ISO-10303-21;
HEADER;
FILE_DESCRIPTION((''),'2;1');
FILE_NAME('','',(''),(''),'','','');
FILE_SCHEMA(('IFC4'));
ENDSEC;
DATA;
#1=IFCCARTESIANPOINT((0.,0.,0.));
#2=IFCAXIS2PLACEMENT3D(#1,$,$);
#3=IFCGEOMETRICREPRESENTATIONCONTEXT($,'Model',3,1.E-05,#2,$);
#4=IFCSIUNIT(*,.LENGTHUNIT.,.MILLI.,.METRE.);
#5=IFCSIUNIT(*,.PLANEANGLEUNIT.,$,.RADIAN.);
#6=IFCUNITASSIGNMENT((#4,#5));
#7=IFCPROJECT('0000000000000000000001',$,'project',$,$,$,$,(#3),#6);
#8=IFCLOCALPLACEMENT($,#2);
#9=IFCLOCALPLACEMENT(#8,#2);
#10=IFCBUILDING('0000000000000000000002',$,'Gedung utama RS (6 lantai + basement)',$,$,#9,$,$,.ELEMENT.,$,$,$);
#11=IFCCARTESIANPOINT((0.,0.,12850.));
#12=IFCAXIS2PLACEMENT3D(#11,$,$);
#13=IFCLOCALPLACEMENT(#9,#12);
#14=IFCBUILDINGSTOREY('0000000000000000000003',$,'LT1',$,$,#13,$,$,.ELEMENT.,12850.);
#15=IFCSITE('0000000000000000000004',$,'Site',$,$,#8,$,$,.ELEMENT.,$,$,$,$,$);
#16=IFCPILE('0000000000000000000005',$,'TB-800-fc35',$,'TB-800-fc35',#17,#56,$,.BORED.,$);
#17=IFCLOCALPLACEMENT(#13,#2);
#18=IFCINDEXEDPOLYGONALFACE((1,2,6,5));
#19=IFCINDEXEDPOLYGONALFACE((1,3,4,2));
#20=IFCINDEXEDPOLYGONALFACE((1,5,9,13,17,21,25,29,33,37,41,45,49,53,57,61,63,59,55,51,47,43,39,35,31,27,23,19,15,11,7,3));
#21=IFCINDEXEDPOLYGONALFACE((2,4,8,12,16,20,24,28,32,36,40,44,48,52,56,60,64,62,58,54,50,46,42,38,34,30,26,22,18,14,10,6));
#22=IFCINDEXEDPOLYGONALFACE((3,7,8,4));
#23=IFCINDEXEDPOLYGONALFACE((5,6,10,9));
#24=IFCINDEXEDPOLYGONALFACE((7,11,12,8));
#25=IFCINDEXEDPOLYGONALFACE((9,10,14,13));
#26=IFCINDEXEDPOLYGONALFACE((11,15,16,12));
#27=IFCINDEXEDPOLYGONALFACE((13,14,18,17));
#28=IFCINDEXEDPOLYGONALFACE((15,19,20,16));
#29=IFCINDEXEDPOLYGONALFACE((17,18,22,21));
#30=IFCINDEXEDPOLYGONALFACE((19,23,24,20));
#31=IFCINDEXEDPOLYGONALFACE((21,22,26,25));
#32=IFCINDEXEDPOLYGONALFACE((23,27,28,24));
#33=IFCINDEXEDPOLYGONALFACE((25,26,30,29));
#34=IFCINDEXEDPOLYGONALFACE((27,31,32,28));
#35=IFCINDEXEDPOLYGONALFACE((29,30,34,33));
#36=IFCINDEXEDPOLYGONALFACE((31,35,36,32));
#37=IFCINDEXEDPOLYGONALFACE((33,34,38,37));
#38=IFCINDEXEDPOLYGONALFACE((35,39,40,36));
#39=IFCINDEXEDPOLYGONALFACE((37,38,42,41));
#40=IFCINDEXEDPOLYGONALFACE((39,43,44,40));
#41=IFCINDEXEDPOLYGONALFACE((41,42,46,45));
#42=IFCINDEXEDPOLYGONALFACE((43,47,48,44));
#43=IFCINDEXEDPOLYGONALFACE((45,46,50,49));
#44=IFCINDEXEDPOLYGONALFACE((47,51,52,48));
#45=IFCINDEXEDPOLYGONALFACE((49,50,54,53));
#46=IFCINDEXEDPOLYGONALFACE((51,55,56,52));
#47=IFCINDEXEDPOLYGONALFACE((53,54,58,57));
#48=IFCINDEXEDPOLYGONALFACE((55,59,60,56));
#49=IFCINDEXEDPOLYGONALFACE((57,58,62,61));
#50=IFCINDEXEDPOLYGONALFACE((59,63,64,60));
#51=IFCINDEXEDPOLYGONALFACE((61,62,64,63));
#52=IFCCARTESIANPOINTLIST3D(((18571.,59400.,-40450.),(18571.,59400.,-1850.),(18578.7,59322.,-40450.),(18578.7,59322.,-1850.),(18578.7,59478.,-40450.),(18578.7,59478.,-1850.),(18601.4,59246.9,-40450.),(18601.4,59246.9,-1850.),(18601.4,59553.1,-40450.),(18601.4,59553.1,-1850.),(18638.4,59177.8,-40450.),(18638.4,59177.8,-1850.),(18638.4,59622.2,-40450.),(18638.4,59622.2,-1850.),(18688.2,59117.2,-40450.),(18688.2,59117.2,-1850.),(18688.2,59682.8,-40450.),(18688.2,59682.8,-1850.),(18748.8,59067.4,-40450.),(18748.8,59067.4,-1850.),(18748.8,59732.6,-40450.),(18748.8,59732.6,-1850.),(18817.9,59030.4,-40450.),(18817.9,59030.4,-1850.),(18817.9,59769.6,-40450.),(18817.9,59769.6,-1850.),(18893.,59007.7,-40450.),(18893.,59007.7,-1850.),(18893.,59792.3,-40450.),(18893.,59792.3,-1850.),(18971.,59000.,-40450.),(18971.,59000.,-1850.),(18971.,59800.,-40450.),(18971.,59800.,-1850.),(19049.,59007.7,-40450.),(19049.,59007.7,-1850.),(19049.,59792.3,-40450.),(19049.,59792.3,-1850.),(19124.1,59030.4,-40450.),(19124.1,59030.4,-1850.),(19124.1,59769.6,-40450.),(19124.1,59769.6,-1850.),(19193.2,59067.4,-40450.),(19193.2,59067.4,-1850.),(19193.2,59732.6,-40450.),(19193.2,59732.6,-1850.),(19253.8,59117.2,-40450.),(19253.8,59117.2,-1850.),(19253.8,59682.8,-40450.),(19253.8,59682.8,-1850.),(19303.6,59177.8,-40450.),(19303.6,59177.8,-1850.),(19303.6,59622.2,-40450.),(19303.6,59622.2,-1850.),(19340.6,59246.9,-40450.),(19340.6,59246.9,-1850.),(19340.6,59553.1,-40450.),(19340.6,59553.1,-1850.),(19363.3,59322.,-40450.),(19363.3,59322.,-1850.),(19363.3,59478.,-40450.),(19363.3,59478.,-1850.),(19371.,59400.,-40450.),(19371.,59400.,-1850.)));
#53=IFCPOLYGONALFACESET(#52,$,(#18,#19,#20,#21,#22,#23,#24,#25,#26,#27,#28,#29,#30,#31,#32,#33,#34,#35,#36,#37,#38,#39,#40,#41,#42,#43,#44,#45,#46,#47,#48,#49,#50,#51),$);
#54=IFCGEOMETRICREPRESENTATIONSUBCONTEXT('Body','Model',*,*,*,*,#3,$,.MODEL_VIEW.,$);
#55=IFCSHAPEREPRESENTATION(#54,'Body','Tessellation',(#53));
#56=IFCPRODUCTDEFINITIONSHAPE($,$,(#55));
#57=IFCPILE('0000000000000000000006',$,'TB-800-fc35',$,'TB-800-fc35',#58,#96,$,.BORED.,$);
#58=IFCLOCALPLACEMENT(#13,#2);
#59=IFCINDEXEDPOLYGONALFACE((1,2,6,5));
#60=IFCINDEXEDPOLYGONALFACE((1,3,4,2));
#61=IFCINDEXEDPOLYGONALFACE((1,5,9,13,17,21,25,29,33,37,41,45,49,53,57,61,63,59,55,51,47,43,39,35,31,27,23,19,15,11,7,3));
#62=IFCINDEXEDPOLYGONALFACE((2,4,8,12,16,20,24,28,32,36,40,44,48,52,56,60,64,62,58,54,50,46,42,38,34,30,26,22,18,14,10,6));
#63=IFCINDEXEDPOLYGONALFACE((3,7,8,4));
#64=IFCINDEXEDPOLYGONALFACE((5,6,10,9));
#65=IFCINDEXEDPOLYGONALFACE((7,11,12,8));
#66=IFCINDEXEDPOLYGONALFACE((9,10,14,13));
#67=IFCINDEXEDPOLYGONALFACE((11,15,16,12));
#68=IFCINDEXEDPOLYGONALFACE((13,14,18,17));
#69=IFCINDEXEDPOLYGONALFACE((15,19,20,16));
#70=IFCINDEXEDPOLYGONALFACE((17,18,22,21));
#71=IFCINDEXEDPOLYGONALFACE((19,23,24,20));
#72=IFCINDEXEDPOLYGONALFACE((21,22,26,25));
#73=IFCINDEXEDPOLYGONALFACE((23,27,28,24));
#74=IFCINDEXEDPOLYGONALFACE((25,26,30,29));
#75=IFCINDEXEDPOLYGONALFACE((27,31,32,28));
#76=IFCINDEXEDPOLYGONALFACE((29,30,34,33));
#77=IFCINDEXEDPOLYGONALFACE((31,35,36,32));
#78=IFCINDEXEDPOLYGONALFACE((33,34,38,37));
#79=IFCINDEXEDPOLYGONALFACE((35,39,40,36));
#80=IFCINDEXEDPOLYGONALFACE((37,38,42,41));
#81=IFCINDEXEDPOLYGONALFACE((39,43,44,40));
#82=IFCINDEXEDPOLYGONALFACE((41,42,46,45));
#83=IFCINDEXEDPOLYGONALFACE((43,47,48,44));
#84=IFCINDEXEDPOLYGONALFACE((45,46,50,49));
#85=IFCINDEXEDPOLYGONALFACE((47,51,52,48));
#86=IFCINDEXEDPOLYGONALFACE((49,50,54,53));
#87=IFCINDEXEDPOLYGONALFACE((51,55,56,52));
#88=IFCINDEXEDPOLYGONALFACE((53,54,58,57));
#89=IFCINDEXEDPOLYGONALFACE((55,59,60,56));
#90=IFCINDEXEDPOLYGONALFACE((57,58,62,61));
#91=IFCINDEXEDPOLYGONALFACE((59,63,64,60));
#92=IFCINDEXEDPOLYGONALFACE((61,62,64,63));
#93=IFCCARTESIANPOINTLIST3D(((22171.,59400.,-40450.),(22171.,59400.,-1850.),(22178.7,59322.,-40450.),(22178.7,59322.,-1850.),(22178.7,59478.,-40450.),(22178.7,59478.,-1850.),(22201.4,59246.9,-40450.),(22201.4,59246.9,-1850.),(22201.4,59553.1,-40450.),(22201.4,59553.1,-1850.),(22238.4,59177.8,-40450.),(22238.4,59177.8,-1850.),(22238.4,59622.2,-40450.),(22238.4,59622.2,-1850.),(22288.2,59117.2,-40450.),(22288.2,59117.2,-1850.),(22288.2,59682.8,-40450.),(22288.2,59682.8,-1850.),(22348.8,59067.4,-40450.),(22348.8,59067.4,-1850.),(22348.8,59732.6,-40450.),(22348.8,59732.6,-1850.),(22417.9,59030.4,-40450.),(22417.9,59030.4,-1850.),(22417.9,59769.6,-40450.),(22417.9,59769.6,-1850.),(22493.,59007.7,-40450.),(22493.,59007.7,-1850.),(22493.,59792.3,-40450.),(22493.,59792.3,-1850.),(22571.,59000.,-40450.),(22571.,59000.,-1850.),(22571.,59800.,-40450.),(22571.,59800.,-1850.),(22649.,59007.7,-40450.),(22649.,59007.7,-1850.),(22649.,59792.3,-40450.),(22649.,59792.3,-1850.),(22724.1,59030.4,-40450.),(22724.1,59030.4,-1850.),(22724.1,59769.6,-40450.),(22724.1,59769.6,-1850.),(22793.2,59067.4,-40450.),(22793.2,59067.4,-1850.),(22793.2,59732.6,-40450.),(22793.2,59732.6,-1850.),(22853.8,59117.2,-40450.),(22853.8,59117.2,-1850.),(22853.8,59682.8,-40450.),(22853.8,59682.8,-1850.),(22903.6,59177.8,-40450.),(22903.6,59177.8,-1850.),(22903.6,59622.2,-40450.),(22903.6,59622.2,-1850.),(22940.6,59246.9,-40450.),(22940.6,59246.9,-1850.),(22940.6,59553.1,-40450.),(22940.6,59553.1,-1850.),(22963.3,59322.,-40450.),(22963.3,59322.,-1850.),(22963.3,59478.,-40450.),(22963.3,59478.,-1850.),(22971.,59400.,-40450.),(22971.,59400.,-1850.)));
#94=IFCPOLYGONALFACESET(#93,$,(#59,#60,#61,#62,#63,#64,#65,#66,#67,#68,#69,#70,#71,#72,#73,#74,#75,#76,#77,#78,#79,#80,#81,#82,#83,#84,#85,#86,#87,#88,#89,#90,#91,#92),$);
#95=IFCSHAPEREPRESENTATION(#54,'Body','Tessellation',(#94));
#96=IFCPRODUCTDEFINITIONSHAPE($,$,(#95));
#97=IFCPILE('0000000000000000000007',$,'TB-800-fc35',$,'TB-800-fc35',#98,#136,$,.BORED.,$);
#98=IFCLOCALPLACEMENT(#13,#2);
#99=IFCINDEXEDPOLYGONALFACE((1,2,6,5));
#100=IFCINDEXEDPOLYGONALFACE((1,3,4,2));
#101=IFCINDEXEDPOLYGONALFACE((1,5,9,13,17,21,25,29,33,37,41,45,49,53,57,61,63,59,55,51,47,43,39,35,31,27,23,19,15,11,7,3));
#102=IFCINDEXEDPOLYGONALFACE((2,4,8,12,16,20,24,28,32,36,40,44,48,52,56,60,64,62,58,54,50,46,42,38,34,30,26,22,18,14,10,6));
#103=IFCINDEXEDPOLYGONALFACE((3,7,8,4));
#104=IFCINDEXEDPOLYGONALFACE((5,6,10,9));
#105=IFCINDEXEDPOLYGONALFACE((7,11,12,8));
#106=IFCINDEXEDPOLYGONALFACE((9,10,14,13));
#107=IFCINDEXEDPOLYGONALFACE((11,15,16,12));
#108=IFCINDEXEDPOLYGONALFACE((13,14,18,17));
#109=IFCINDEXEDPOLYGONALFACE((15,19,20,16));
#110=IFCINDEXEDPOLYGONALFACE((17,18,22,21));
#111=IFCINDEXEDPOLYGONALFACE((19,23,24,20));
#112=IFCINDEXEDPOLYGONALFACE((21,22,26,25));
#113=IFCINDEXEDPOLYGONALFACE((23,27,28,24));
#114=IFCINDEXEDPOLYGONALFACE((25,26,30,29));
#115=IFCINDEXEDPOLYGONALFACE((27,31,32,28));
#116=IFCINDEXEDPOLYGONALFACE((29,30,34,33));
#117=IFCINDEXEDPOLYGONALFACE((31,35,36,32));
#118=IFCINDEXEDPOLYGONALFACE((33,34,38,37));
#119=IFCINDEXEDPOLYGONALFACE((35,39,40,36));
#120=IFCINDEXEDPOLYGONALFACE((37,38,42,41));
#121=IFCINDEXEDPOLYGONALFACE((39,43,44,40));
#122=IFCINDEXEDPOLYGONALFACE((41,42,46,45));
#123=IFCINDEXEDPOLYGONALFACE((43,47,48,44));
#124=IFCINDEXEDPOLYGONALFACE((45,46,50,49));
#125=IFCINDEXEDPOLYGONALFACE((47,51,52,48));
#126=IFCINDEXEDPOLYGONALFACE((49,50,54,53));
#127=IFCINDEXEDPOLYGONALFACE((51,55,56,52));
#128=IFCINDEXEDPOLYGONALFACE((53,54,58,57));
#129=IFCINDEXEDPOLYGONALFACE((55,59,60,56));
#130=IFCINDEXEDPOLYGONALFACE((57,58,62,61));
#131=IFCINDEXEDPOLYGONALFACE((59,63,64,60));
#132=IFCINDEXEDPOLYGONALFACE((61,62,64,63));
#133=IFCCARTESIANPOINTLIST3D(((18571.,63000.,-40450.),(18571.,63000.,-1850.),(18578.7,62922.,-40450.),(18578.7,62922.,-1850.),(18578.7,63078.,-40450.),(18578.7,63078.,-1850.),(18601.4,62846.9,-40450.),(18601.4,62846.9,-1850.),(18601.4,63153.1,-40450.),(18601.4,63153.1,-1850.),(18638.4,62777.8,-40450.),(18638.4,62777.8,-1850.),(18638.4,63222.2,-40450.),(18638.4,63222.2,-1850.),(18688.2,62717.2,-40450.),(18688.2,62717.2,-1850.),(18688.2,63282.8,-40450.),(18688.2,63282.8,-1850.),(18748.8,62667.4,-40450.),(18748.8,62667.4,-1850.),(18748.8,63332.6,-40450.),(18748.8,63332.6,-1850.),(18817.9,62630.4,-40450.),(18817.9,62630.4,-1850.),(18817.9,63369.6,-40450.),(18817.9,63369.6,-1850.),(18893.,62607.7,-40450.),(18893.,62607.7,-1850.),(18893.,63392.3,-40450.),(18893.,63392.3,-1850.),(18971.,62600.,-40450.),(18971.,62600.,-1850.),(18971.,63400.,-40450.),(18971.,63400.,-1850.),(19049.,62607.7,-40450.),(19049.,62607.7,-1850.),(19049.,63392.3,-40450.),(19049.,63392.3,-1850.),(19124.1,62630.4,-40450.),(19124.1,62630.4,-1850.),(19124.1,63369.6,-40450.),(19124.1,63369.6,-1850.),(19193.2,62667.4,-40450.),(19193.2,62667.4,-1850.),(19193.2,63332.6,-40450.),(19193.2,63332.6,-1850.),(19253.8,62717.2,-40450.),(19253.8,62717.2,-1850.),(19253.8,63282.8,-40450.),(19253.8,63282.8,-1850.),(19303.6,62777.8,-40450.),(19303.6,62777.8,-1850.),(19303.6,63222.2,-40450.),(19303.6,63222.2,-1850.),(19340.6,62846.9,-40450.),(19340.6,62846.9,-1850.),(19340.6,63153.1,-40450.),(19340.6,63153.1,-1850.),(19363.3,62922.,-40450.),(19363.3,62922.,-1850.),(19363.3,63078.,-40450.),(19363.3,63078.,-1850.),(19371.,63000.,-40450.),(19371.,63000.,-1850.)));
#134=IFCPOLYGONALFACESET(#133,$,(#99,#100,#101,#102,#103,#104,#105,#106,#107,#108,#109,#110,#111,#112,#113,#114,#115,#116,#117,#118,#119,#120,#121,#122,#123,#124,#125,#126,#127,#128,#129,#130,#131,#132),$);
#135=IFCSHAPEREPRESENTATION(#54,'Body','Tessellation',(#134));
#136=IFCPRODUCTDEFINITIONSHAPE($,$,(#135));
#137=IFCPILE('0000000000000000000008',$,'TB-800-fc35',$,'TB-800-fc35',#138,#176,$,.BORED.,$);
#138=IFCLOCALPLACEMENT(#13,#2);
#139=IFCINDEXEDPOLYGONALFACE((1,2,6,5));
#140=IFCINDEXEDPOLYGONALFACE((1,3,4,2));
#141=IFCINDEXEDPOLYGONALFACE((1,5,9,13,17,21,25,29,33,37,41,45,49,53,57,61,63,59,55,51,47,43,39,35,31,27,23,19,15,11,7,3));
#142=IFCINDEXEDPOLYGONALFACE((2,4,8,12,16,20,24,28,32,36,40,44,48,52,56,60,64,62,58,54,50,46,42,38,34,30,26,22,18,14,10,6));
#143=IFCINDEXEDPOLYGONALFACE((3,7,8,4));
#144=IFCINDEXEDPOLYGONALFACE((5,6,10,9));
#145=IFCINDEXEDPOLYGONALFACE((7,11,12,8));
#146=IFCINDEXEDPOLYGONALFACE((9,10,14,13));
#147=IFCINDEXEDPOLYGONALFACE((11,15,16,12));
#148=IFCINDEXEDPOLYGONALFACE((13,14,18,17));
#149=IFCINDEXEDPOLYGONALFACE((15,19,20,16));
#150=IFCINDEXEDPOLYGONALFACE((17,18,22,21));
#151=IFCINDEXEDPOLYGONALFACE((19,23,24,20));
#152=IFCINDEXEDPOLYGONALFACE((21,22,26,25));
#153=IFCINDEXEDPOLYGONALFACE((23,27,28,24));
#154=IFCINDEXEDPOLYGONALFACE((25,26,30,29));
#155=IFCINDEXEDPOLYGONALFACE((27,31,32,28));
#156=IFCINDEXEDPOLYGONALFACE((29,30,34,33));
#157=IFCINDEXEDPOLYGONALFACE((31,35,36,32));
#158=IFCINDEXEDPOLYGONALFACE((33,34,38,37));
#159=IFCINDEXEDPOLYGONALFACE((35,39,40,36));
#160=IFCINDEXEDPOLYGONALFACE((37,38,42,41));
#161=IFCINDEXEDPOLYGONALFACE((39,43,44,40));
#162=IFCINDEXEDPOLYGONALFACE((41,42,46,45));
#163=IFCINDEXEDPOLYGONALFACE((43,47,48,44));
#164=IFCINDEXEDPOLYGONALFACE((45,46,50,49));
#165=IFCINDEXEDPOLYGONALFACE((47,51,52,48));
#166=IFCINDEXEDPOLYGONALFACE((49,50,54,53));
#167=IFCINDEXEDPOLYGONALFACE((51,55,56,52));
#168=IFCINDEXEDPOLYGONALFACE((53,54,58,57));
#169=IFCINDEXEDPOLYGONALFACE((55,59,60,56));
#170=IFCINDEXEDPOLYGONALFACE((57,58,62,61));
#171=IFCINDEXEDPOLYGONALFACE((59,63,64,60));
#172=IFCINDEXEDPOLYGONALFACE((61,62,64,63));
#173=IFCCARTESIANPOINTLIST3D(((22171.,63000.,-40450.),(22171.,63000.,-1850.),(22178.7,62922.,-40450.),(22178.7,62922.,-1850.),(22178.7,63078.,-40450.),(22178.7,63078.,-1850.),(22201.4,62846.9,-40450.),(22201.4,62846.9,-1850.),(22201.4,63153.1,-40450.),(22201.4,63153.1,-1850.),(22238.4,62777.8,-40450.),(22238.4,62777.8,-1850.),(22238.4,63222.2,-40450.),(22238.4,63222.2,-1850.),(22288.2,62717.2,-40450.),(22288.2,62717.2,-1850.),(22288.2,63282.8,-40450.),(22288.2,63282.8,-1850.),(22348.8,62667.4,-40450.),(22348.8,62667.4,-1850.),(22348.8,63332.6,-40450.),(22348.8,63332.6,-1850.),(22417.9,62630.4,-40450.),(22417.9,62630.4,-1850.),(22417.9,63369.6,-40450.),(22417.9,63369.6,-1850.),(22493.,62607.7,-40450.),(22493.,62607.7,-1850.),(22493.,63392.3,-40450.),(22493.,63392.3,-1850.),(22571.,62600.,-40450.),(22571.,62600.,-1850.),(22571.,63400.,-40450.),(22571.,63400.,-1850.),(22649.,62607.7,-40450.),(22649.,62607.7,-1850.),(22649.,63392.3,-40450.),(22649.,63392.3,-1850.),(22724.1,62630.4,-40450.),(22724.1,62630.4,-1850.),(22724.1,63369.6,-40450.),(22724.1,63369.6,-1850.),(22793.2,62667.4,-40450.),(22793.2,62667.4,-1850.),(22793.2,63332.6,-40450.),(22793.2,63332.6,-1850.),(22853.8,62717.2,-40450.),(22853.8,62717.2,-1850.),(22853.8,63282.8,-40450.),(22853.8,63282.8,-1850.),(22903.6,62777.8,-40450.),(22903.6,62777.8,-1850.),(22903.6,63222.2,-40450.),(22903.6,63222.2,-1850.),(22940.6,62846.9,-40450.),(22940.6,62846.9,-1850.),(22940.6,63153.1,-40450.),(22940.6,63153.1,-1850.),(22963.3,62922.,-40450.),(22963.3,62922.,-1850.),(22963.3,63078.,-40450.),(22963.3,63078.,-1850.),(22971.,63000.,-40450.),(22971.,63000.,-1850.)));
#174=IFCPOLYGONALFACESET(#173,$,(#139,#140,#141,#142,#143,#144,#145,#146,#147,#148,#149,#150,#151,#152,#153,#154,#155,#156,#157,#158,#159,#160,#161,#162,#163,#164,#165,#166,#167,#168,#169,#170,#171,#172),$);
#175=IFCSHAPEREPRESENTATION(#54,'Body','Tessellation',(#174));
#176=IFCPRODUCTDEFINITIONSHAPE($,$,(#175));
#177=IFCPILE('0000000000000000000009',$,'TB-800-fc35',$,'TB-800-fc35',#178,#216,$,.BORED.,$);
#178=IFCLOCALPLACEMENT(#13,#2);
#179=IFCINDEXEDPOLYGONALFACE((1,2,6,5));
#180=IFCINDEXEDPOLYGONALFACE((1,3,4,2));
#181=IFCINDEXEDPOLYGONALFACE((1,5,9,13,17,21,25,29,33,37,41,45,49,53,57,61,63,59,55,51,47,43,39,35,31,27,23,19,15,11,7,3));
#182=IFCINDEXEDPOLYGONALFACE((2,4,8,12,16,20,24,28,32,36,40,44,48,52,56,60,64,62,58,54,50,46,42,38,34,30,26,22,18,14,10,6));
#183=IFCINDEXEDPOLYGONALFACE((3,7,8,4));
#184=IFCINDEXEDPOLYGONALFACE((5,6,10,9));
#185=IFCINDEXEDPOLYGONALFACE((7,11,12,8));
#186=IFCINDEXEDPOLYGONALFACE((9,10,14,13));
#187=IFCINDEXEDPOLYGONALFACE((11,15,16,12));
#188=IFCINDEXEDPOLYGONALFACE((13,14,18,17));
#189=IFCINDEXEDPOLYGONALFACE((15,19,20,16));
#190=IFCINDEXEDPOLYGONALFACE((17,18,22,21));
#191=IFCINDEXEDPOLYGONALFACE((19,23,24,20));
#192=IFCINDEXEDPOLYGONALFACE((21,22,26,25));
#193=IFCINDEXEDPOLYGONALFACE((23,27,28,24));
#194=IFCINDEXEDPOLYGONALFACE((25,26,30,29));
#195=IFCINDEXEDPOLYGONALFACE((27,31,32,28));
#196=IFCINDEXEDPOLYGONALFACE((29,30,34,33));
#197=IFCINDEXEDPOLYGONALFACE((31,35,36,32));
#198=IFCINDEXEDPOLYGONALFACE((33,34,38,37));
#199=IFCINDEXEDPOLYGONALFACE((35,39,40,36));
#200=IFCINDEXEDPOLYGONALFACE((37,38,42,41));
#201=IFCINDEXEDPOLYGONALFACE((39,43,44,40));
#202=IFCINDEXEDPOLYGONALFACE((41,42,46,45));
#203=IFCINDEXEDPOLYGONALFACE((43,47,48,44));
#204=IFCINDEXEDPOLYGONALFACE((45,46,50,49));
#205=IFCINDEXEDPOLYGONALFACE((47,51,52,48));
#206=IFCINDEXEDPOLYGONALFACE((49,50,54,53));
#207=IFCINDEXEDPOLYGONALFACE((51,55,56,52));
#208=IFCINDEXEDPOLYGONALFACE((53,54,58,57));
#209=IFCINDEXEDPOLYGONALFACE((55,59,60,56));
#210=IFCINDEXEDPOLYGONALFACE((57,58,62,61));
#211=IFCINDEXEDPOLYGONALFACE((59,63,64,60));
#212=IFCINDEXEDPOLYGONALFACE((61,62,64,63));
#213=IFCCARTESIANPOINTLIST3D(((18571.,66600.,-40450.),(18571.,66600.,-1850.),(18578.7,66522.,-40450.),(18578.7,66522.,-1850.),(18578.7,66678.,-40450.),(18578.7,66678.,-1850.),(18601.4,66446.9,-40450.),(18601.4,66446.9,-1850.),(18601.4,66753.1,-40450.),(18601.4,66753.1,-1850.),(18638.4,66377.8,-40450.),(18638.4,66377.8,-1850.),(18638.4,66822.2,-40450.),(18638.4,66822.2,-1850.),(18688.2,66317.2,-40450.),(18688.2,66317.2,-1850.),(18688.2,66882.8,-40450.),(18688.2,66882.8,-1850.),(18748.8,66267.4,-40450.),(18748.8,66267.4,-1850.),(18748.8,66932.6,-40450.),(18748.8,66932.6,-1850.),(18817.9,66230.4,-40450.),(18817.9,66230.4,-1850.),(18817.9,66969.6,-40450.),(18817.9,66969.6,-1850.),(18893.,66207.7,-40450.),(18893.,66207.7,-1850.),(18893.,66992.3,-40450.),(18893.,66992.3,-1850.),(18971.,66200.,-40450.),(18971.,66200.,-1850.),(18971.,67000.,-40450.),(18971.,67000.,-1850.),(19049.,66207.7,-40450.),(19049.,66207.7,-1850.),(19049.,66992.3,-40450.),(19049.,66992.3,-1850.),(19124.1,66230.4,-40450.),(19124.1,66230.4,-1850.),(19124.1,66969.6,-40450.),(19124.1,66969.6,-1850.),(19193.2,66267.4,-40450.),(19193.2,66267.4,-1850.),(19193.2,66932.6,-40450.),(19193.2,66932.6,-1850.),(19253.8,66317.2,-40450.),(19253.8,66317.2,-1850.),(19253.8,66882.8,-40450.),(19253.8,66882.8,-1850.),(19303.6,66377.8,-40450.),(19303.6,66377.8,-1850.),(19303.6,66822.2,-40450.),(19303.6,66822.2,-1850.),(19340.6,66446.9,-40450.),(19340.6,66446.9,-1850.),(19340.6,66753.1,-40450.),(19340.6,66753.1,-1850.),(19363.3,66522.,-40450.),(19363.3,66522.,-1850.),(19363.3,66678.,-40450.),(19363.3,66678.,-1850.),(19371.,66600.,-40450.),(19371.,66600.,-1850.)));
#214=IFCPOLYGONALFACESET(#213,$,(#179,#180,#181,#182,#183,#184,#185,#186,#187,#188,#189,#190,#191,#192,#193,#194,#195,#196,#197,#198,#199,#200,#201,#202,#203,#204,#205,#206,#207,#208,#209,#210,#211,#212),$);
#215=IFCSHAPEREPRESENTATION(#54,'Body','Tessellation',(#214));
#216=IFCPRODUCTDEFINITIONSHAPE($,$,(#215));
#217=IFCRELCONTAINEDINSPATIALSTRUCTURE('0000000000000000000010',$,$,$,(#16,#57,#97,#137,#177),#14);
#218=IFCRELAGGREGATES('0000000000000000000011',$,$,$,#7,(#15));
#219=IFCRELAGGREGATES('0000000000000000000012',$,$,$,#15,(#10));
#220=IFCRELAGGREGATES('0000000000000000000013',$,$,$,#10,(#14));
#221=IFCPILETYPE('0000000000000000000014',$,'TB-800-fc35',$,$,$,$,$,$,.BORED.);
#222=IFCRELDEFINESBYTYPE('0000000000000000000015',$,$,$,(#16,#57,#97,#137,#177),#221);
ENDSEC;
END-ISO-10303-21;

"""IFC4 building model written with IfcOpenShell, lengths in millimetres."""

from ifc_helpers import new_model, si_unit, frame, origin, origin_2d, place, context, subcontext, project, spatial, circle, extrude, material_profile, profile_set, profile_usage, type_object, element, save


model = new_model("IFC4")

# Units and contexts
model_context = context("Model", 3, precision=1e-05, world=origin())
body_context = subcontext(model_context, "Body", "Model", "MODEL_VIEW")
ifc_project = project(units=[si_unit("LENGTHUNIT", "METRE", prefix="MILLI"), si_unit("PLANEANGLEUNIT", "RADIAN")], contexts=[model_context])

# Site, building, storey
site_placement = place(None, origin())
site = spatial("IfcSite", under=ifc_project, at=site_placement, Name="Site", CompositionType="ELEMENT")
building_placement = place(site_placement, origin())
building = spatial("IfcBuilding", under=site, at=building_placement, Name="Gedung utama RS (6 lantai + basement)", CompositionType="ELEMENT")
storey_placement = place(building_placement, frame((0.0, 0.0, 12850.0)))
storey = spatial("IfcBuildingStorey", under=building, at=storey_placement, Name="LT1", CompositionType="ELEMENT", Elevation=12850.0)

# Piles
ifc_material_profile = material_profile(None, circle(Radius=400.0, at=origin_2d()), Name="TB-800-fc35")
ifc_profile_set = profile_set([ifc_material_profile], Name="TB-800-fc35")
ifc_profile_usage = profile_usage(ifc_profile_set, cardinal=5)
pile_type = type_object("IfcPileType", Name="TB-800-fc35", PredefinedType="BORED", material=ifc_profile_set)
for number, where, z_axis, x_axis, name in (
    (1, (18971.0, 59400.0, -40450.0), (0.0, 0.0, 1.0), (1.0, 0.0, 0.0), "TB-800-fc35"),
    (2, (22571.0, 59400.0, -40450.0), (0.0, 0.0, 1.0), (1.0, 0.0, 0.0), "TB-800-fc35"),
    (3, (18971.0, 63000.0, -40450.0), (0.0, 0.0, 1.0), (1.0, 0.0, 0.0), "TB-800-fc35"),
    (4, (22571.0, 63000.0, -40450.0), (0.0, 0.0, 1.0), (1.0, 0.0, 0.0), "TB-800-fc35"),
    (5, (18971.0, 66600.0, -40450.0), (0.0, 0.0, 1.0), (1.0, 0.0, 0.0), "TB-800-fc35"),
):
    element("IfcPile", number, at=place(storey_placement, frame(where, z_axis=z_axis, x_axis=x_axis)), inside=storey, type_object=pile_type, material=ifc_profile_usage, Name=name, ObjectType="TB-800-fc35", PredefinedType="BORED", context=body_context, shape_type="SweptSolid", body=[
        extrude(circle(Radius=400.0, at=origin_2d()), origin(), (0.0, 0.0, 1.0), 38600.0),
    ])

save(model, "model.ifc")
